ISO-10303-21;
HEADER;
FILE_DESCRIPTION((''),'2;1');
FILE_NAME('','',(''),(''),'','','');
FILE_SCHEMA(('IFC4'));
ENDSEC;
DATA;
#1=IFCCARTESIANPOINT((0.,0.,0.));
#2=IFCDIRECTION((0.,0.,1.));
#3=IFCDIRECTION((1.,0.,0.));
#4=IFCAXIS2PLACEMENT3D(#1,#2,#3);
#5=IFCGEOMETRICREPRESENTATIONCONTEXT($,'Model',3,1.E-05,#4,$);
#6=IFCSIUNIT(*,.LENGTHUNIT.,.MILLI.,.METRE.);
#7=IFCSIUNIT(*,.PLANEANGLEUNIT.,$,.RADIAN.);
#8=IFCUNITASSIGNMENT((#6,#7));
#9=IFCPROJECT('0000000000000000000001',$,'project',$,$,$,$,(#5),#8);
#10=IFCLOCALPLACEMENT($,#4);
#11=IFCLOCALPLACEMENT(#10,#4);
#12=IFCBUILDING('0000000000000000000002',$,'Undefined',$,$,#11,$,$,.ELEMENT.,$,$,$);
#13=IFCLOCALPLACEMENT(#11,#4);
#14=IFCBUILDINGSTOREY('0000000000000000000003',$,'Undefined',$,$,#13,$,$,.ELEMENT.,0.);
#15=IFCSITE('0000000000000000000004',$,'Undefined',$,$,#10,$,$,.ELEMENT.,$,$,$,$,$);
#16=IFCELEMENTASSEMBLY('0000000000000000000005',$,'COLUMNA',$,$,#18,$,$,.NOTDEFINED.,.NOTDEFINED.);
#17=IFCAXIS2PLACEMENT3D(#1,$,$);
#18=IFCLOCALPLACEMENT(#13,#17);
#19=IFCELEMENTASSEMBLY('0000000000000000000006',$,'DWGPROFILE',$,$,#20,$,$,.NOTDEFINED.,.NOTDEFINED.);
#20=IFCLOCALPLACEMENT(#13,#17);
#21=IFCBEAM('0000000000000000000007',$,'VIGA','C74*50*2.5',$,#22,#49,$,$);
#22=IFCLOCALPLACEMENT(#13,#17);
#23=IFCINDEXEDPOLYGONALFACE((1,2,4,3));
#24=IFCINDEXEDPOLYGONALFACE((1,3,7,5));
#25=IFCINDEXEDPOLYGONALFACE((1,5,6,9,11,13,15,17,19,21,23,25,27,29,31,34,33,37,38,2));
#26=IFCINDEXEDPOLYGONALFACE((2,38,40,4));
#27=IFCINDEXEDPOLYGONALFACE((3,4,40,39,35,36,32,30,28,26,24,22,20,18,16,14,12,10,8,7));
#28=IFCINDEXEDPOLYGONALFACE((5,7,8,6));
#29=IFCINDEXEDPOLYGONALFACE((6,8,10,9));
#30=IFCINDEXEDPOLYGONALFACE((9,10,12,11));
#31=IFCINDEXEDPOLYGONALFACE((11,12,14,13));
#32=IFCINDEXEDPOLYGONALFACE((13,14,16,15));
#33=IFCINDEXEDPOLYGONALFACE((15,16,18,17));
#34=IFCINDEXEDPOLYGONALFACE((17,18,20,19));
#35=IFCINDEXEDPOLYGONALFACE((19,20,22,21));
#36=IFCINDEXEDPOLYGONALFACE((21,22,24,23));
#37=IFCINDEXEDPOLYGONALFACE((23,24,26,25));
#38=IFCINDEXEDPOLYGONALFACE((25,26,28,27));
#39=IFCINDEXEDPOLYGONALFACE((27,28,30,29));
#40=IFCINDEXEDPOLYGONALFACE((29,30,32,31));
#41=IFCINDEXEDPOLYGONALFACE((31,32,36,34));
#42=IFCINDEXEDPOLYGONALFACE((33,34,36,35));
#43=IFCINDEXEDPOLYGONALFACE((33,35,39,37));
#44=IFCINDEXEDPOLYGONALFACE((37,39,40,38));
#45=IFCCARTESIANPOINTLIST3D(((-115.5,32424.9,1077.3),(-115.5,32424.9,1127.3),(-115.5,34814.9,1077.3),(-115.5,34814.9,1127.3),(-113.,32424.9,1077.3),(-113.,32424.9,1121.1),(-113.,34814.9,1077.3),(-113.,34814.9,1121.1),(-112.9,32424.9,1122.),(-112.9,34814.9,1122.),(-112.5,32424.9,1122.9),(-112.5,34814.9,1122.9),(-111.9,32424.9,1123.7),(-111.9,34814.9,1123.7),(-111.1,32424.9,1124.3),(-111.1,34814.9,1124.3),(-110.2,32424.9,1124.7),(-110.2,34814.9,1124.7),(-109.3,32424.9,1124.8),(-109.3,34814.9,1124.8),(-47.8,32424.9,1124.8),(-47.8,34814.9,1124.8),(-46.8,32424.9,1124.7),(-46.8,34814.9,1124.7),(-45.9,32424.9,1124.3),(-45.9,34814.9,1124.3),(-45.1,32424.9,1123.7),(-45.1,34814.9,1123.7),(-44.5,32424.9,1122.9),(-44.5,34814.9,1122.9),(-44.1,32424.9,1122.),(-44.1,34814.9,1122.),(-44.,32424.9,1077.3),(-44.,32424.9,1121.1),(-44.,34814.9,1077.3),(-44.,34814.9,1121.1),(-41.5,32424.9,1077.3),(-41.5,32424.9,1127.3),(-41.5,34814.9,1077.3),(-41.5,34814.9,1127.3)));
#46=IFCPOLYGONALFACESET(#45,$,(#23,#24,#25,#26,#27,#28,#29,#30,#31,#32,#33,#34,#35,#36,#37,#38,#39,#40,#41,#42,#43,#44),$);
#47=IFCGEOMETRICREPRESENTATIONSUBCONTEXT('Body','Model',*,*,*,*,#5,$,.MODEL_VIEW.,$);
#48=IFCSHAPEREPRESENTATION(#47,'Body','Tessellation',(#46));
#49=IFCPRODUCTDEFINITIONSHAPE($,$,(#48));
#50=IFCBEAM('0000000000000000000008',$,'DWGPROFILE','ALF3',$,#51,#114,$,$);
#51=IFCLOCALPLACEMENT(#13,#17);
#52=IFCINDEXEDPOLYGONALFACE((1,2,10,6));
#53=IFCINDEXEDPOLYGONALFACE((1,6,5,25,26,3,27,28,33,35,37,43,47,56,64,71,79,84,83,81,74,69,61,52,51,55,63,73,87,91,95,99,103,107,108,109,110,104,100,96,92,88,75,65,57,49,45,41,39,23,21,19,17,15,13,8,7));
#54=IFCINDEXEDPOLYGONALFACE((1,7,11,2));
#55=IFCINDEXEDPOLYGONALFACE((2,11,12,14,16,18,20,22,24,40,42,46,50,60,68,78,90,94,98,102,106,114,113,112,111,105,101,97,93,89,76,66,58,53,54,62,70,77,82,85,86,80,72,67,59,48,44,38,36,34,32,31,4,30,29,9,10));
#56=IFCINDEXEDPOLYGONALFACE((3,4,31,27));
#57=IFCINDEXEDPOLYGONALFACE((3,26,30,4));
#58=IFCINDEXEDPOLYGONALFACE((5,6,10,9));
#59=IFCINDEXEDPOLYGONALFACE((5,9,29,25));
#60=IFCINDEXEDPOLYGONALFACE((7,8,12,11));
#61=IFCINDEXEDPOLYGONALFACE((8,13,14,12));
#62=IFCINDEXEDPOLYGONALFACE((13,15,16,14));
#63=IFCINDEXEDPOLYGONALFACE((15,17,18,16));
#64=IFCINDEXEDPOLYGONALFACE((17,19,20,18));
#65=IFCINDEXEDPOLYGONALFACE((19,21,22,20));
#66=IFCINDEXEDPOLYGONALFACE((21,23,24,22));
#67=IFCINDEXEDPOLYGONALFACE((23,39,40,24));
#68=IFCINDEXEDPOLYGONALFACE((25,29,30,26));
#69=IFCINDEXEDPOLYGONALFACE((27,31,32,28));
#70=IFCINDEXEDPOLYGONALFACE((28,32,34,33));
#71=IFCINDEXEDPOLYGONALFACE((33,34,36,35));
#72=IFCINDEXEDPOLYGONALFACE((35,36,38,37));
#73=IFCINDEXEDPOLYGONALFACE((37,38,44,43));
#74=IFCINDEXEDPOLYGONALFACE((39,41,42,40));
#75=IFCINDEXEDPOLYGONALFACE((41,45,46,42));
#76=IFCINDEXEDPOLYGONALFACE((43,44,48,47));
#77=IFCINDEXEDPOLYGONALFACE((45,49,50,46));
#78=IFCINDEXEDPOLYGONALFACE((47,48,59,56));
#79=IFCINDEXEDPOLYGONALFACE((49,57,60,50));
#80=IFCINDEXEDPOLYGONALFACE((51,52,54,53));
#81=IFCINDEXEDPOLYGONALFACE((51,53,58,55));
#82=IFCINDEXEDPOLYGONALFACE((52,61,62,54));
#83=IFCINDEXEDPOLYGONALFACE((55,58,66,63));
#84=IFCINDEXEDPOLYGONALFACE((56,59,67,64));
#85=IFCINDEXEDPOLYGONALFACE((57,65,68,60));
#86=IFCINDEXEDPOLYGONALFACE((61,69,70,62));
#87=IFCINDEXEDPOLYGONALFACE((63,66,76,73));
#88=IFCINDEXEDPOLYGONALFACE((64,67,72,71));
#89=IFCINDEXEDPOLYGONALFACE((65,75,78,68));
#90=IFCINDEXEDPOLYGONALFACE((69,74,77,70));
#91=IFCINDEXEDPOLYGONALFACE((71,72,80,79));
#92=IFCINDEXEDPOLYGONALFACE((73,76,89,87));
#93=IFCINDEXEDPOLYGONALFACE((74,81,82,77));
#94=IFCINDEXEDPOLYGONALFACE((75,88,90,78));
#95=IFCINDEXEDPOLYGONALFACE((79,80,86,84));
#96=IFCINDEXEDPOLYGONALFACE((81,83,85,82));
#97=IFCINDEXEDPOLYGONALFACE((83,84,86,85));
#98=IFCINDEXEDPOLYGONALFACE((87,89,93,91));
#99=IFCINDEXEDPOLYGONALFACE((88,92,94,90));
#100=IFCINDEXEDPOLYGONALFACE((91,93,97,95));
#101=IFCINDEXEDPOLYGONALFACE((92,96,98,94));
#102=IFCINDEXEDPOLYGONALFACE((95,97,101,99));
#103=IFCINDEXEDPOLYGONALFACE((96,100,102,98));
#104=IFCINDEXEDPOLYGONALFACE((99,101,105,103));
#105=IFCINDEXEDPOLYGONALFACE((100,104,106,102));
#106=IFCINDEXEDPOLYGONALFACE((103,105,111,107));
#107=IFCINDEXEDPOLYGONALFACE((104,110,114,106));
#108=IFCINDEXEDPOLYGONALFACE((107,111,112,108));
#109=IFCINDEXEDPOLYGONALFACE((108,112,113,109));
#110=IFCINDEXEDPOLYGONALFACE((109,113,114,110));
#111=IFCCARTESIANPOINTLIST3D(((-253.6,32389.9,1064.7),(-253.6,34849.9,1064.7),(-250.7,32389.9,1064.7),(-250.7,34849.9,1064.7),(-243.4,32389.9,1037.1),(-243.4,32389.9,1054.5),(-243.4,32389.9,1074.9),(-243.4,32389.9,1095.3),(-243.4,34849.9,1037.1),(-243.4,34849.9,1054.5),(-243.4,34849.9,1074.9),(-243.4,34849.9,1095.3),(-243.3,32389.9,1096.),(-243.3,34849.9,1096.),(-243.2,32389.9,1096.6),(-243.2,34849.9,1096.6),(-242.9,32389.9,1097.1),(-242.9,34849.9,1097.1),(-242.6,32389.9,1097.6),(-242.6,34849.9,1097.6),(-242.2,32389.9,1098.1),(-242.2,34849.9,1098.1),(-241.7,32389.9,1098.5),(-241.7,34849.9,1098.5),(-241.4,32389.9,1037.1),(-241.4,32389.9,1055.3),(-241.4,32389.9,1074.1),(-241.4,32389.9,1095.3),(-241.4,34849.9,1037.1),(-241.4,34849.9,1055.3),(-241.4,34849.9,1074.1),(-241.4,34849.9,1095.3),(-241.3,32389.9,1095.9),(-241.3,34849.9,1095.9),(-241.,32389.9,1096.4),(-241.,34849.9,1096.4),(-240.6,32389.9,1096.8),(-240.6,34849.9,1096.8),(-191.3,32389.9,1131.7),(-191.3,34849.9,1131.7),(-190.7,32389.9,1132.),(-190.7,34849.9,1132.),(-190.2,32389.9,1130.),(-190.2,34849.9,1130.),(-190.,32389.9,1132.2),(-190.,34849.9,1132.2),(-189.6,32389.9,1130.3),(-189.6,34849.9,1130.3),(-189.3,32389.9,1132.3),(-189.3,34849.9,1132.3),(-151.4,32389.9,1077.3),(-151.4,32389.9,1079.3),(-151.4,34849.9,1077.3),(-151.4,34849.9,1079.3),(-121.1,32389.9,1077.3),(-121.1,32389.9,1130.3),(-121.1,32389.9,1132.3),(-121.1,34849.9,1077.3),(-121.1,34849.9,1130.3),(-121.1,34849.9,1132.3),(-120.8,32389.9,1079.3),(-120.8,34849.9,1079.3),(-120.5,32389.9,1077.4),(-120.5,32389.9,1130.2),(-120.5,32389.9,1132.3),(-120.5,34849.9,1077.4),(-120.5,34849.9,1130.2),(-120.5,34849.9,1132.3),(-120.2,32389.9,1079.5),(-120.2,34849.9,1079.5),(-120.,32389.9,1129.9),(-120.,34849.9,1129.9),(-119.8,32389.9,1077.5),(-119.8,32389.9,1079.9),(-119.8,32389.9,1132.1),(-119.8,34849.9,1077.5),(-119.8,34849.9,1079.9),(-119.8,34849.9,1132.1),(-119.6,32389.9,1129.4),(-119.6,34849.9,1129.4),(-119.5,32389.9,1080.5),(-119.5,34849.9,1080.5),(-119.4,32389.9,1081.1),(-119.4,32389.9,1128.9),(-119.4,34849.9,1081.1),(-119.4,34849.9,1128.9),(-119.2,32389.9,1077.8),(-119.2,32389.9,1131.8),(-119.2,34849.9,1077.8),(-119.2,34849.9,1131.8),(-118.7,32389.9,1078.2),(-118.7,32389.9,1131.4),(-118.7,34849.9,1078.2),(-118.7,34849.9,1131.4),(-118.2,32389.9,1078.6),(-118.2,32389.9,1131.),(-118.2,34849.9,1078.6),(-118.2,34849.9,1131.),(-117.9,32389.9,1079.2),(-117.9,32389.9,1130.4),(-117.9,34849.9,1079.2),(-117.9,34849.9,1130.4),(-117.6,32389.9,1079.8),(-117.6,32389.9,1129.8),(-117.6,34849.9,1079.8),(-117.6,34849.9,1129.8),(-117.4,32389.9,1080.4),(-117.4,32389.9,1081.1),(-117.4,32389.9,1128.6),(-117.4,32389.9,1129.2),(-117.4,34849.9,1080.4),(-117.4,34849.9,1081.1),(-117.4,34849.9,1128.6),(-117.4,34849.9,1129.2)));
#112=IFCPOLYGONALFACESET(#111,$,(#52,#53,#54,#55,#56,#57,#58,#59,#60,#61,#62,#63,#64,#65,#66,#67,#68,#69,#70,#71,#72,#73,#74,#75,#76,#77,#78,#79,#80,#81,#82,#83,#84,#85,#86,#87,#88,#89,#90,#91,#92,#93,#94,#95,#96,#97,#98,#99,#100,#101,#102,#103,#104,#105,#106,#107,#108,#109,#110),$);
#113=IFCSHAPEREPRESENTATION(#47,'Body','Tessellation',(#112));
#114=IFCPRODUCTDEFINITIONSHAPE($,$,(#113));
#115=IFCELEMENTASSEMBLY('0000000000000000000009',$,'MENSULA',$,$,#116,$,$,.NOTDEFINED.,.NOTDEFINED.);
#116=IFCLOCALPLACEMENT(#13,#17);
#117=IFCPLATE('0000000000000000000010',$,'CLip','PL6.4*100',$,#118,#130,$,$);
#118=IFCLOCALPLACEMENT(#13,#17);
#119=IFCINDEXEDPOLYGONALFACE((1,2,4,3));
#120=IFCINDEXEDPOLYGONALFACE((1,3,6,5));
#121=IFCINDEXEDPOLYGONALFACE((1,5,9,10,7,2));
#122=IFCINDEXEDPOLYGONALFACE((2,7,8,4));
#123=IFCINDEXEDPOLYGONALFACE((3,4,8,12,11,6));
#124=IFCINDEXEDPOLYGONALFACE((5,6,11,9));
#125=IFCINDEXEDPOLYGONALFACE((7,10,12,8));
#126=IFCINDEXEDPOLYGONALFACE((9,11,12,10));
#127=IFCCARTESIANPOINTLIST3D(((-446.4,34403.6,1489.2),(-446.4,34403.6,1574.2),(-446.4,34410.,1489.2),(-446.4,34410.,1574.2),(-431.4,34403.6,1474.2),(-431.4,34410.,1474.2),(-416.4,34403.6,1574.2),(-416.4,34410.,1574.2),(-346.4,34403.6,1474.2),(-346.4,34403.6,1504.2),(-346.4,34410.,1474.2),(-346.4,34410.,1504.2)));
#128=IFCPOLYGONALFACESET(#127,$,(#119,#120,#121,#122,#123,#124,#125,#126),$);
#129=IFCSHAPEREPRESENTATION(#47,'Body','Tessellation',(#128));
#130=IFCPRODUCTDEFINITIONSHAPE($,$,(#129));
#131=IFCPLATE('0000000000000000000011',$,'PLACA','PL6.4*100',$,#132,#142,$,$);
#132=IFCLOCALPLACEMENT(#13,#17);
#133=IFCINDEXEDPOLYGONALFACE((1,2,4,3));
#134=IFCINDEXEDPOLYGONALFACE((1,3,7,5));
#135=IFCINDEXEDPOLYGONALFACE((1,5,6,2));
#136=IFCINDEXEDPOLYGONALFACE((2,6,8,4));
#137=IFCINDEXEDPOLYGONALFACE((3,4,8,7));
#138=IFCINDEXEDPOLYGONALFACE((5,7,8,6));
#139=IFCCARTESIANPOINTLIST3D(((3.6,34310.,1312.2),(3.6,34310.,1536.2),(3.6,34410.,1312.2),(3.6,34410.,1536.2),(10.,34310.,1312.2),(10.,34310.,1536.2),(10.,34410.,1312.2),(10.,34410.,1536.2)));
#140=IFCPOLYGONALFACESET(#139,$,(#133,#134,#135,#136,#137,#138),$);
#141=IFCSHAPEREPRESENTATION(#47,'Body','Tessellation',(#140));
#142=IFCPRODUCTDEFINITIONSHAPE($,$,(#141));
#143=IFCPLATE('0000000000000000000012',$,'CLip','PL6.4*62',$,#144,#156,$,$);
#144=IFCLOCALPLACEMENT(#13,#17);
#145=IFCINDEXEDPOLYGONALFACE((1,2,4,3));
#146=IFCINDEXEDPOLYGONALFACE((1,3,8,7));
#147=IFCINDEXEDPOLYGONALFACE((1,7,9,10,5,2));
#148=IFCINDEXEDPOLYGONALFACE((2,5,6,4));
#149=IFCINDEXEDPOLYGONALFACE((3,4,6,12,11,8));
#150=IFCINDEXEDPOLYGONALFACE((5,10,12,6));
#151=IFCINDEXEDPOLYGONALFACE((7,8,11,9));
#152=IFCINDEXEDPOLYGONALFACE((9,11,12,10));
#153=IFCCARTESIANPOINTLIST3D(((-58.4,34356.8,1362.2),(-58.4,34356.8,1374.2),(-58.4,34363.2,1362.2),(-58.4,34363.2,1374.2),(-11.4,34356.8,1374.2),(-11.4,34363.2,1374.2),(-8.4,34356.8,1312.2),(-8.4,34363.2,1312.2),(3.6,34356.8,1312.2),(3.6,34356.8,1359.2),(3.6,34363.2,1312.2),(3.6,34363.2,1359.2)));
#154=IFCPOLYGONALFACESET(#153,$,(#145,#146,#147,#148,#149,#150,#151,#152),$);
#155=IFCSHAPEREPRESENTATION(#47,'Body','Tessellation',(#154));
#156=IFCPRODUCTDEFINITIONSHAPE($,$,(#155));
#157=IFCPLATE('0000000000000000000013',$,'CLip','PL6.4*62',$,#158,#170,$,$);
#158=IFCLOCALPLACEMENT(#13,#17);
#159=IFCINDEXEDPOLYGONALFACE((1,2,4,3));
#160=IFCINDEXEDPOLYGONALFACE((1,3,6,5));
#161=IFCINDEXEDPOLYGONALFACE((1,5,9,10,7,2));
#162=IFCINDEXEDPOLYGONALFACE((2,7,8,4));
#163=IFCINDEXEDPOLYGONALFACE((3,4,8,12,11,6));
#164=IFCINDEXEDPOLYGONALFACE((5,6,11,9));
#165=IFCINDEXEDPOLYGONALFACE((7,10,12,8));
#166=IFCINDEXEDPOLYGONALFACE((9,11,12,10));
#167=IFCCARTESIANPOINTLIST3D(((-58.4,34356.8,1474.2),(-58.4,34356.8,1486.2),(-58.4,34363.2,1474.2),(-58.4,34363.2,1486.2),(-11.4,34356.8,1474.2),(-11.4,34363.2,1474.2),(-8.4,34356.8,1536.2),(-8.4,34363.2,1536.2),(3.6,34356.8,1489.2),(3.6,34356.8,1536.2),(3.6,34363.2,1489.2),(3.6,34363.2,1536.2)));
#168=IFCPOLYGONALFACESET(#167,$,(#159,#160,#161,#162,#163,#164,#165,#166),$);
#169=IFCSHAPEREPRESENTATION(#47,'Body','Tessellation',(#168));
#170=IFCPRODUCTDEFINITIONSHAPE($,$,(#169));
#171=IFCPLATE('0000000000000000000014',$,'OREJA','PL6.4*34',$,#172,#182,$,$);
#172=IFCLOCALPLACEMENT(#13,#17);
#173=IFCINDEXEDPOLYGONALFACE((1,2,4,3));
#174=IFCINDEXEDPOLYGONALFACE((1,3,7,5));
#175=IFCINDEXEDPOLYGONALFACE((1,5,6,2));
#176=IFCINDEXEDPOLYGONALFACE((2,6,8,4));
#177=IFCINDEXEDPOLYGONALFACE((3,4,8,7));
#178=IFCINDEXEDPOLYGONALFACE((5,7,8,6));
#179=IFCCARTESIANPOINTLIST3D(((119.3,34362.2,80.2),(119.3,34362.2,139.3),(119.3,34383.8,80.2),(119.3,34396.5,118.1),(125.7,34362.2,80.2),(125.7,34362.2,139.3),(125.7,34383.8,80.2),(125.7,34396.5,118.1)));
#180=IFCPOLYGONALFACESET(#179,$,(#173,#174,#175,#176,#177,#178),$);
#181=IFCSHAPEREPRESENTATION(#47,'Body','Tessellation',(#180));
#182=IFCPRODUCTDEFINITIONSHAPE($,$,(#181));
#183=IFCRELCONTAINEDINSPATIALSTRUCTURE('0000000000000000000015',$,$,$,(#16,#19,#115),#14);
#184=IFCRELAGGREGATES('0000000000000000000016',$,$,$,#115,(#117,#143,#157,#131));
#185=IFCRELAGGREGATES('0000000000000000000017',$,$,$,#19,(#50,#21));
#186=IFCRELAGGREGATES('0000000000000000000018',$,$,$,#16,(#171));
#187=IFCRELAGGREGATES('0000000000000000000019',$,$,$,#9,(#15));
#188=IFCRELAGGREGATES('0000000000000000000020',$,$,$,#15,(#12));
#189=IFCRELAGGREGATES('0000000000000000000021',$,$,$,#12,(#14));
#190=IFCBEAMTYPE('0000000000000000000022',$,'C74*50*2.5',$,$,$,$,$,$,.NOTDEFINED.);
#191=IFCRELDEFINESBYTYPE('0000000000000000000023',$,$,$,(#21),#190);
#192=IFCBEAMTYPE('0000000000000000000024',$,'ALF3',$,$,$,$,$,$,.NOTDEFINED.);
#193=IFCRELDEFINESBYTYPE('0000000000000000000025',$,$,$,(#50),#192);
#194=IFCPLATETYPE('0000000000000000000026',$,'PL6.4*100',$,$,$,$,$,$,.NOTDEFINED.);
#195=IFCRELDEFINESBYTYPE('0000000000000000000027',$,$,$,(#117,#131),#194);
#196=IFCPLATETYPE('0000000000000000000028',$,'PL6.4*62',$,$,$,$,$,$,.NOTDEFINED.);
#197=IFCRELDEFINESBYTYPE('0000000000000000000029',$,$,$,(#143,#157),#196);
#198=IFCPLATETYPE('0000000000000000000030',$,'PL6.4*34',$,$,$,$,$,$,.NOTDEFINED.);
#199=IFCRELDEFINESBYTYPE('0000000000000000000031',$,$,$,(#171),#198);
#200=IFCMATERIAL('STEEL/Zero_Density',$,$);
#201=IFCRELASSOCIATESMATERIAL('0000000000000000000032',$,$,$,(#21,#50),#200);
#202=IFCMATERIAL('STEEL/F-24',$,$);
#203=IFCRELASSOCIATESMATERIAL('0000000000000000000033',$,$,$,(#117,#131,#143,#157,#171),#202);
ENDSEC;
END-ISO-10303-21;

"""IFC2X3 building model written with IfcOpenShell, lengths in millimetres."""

from ifc_helpers import new_model, si_unit, frame, origin_with_axes, origin_2d_with_axis, place, context, subcontext, project, spatial, polyline, u_section, outline, extrude, material, type_object, element, aggregate, save


model = new_model("IFC2X3")

# Units and contexts
model_context = context("Model", 3, precision=1e-05, world=origin_with_axes())
body_context = subcontext(model_context, "Body", "Model", "MODEL_VIEW")
ifc_project = project(units=[si_unit("LENGTHUNIT", "METRE", prefix="MILLI"), si_unit("PLANEANGLEUNIT", "RADIAN")], contexts=[model_context])

# Site, building, storey
site_placement = place(None, origin_with_axes())
site = spatial("IfcSite", under=ifc_project, at=site_placement, Name="Undefined", CompositionType="ELEMENT")
building_placement = place(site_placement, origin_with_axes())
building = spatial("IfcBuilding", under=site, at=building_placement, Name="Undefined", CompositionType="ELEMENT")
storey_placement = place(building_placement, origin_with_axes())
storey = spatial("IfcBuildingStorey", under=building, at=storey_placement, Name="Undefined", CompositionType="ELEMENT", Elevation=0.0)

# Element assembly
assembly_1_placement = place(storey_placement, origin_with_axes())
assembly_1 = element("IfcElementAssembly", 1, at=assembly_1_placement, inside=storey, Name="COLUMNA", AssemblyPlace="NOTDEFINED", PredefinedType="NOTDEFINED")
ifc_material_1 = material(Name="STEEL/F-24")

# Element assembly, beams
assembly_2_placement = place(storey_placement, origin_with_axes())
assembly_2 = element("IfcElementAssembly", 2, at=assembly_2_placement, inside=storey, Name="DWGPROFILE", AssemblyPlace="NOTDEFINED", PredefinedType="NOTDEFINED")
ifc_material_2 = material(Name="STEEL/Zero_Density")
beam_type_1 = type_object("IfcBeamType", Name="C74*50*2.5", PredefinedType="NOTDEFINED")
beam_1_placement = place(assembly_2_placement, frame((-78.5, 34814.9, 1102.3), z_axis=(-1.0, 0.0, 0.0), x_axis=(0.0, -1.0, 0.0)))
beam_1 = element("IfcBeam", 3, at=beam_1_placement, type_object=beam_type_1, material=ifc_material_2, Name="VIGA", Description="C74*50*2.5", context=body_context, shape_type="SweptSolid", body=[
    extrude(u_section(Depth=74.0, FlangeWidth=50.0, WebThickness=2.5, FlangeThickness=2.5, FilletRadius=3.8, at=origin_2d_with_axis()), frame((2390.0, 0.0, 0.0), z_axis=(-1.0, 0.0, 0.0), x_axis=(0.0, -1.0, 0.0)), (0.0, 0.0, 1.0), 2390.0),
])
beam_type_2 = type_object("IfcBeamType", Name="ALF3", PredefinedType="NOTDEFINED")
beam_2_placement = place(assembly_2_placement, frame((-185.5, 34849.9, 1084.7), z_axis=(0.0, 0.0, 1.0), x_axis=(0.0, -1.0, 0.0)))
beam_2 = element("IfcBeam", 4, at=beam_2_placement, type_object=beam_type_2, material=ifc_material_2, Name="DWGPROFILE", Description="ALF3", context=body_context, shape_type="SweptSolid", body=[
    extrude(outline(polyline([(57.9, 10.6), (57.9, -9.8), (68.1, -20.0), (57.9, -30.2), (57.9, -47.6), (55.9, -47.6), (55.9, -29.4), (65.3, -20.0), (55.9, -10.6), (55.9, 10.6), (55.8, 11.2), (55.5, 11.7), (55.1, 12.1), (4.8, 45.3), (4.1, 45.6), (-64.3, 45.6), (-64.9, 45.5), (-65.5, 45.2), (-65.9, 44.7), (-66.1, 44.2), (-66.1, -3.6), (-66.0, -4.2), (-65.7, -4.8), (-65.2, -5.2), (-64.7, -5.4), (-34.1, -5.4), (-34.1, -7.4), (-64.3, -7.4), (-65.0, -7.3), (-65.6, -7.2), (-66.2, -6.9), (-66.8, -6.5), (-67.2, -6.1), (-67.6, -5.5), (-67.9, -4.9), (-68.0, -4.3), (-68.1, -3.6), (-68.1, 43.9), (-68.0, 44.5), (-67.9, 45.1), (-67.6, 45.7), (-67.2, 46.3), (-66.8, 46.7), (-66.2, 47.1), (-65.6, 47.4), (-65.0, 47.5), (-64.3, 47.6), (3.8, 47.6), (4.5, 47.5), (5.2, 47.3), (5.9, 47.0), (56.2, 13.8), (56.7, 13.4), (57.1, 12.9), (57.5, 12.4), (57.7, 11.9), (57.9, 11.3), (57.9, 10.6)])), frame((2460.0, 0.0, 0.0), z_axis=(-1.0, 0.0, 0.0), x_axis=(0.0, -1.0, 0.0)), (0.0, 0.0, 1.0), 2460.0),
])

# Element assembly, plates
assembly_3_placement = place(storey_placement, origin_with_axes())
assembly_3 = element("IfcElementAssembly", 5, at=assembly_3_placement, inside=storey, Name="MENSULA", AssemblyPlace="NOTDEFINED", PredefinedType="NOTDEFINED")
plate_type_1 = type_object("IfcPlateType", Name="PL6.4*100", PredefinedType="NOTDEFINED")
plate_1_placement = place(assembly_3_placement, frame((-446.4, 34406.8, 1474.2), z_axis=(0.0, -1.0, 0.0), x_axis=(1.0, 0.0, 0.0)))
plate_1 = element("IfcPlate", 6, at=plate_1_placement, type_object=plate_type_1, material=ifc_material_1, Name="CLip", Description="PL6.4*100", context=body_context, shape_type="SweptSolid", body=[
    extrude(outline(polyline([(0.0, 15.0), (15.0, 0.0), (100.0, 0.0), (100.0, 30.0), (30.0, 100.0), (0.0, 100.0), (0.0, 15.0)])), frame((0.0, 0.0, -3.2), z_axis=(0.0, 0.0, 1.0), x_axis=(1.0, 0.0, 0.0)), (0.0, 0.0, 1.0), 6.4),
])
plate_2_placement = place(assembly_3_placement, frame((6.8, 34410.0, 1536.2), z_axis=(1.0, 0.0, 0.0), x_axis=(0.0, -1.0, 0.0)))
plate_2 = element("IfcPlate", 7, at=plate_2_placement, type_object=plate_type_1, material=ifc_material_1, Name="PLACA", Description="PL6.4*100", context=body_context, shape_type="SweptSolid", body=[
    extrude(outline(polyline([(0.0, 0.0), (100.0, 0.0), (100.0, 224.0), (0.0, 224.0), (0.0, 0.0)])), frame((0.0, 0.0, -3.2), z_axis=(0.0, 0.0, 1.0), x_axis=(1.0, 0.0, 0.0)), (0.0, 0.0, 1.0), 6.4),
])
plate_type_2 = type_object("IfcPlateType", Name="PL6.4*62", PredefinedType="NOTDEFINED")
plate_3_placement = place(assembly_3_placement, frame((3.6, 34360.0, 1374.2), z_axis=(0.0, -1.0, 0.0), x_axis=(-1.0, 0.0, 0.0)))
plate_3 = element("IfcPlate", 8, at=plate_3_placement, type_object=plate_type_2, material=ifc_material_1, Name="CLip", Description="PL6.4*62", context=body_context, shape_type="SweptSolid", body=[
    extrude(outline(polyline([(0.0, 15.0), (15.0, 0.0), (62.0, 0.0), (62.0, 12.0), (12.0, 62.0), (0.0, 62.0), (0.0, 15.0)])), frame((0.0, 0.0, -3.2), z_axis=(0.0, 0.0, 1.0), x_axis=(1.0, 0.0, 0.0)), (0.0, 0.0, 1.0), 6.4),
])
plate_4_placement = place(assembly_3_placement, frame((3.6, 34360.0, 1474.2), z_axis=(0.0, 1.0, 0.0), x_axis=(-1.0, 0.0, 0.0)))
plate_4 = element("IfcPlate", 9, at=plate_4_placement, type_object=plate_type_2, material=ifc_material_1, Name="CLip", Description="PL6.4*62", context=body_context, shape_type="SweptSolid", body=[
    extrude(outline(polyline([(0.0, 15.0), (15.0, 0.0), (62.0, 0.0), (62.0, 12.0), (12.0, 62.0), (0.0, 62.0), (0.0, 15.0)])), frame((0.0, 0.0, -3.2), z_axis=(0.0, 0.0, 1.0), x_axis=(1.0, 0.0, 0.0)), (0.0, 0.0, 1.0), 6.4),
])
aggregate(assembly_3, [plate_1, plate_3, plate_4, plate_2])

# Plate
plate_type_3 = type_object("IfcPlateType", Name="PL6.4*34", PredefinedType="NOTDEFINED")
plate_5_placement = place(assembly_1_placement, frame((122.5, 34362.2, 80.2), z_axis=(-1.0, 0.0, 0.0), x_axis=(0.0, 0.0, 1.0)))
plate_5 = element("IfcPlate", 10, at=plate_5_placement, type_object=plate_type_3, material=ifc_material_1, Name="OREJA", Description="PL6.4*34", context=body_context, shape_type="SweptSolid", body=[
    extrude(outline(polyline([(0.0, 0.0), (59.0, 0.0), (37.9, 34.3), (0.0, 21.6), (0.0, 0.0)])), frame((0.0, 0.0, -3.2), z_axis=(0.0, 0.0, 1.0), x_axis=(1.0, 0.0, 0.0)), (0.0, 0.0, 1.0), 6.4),
])
aggregate(assembly_2, [beam_2, beam_1])

aggregate(assembly_1, [plate_5])

save(model, "model.ifc")
